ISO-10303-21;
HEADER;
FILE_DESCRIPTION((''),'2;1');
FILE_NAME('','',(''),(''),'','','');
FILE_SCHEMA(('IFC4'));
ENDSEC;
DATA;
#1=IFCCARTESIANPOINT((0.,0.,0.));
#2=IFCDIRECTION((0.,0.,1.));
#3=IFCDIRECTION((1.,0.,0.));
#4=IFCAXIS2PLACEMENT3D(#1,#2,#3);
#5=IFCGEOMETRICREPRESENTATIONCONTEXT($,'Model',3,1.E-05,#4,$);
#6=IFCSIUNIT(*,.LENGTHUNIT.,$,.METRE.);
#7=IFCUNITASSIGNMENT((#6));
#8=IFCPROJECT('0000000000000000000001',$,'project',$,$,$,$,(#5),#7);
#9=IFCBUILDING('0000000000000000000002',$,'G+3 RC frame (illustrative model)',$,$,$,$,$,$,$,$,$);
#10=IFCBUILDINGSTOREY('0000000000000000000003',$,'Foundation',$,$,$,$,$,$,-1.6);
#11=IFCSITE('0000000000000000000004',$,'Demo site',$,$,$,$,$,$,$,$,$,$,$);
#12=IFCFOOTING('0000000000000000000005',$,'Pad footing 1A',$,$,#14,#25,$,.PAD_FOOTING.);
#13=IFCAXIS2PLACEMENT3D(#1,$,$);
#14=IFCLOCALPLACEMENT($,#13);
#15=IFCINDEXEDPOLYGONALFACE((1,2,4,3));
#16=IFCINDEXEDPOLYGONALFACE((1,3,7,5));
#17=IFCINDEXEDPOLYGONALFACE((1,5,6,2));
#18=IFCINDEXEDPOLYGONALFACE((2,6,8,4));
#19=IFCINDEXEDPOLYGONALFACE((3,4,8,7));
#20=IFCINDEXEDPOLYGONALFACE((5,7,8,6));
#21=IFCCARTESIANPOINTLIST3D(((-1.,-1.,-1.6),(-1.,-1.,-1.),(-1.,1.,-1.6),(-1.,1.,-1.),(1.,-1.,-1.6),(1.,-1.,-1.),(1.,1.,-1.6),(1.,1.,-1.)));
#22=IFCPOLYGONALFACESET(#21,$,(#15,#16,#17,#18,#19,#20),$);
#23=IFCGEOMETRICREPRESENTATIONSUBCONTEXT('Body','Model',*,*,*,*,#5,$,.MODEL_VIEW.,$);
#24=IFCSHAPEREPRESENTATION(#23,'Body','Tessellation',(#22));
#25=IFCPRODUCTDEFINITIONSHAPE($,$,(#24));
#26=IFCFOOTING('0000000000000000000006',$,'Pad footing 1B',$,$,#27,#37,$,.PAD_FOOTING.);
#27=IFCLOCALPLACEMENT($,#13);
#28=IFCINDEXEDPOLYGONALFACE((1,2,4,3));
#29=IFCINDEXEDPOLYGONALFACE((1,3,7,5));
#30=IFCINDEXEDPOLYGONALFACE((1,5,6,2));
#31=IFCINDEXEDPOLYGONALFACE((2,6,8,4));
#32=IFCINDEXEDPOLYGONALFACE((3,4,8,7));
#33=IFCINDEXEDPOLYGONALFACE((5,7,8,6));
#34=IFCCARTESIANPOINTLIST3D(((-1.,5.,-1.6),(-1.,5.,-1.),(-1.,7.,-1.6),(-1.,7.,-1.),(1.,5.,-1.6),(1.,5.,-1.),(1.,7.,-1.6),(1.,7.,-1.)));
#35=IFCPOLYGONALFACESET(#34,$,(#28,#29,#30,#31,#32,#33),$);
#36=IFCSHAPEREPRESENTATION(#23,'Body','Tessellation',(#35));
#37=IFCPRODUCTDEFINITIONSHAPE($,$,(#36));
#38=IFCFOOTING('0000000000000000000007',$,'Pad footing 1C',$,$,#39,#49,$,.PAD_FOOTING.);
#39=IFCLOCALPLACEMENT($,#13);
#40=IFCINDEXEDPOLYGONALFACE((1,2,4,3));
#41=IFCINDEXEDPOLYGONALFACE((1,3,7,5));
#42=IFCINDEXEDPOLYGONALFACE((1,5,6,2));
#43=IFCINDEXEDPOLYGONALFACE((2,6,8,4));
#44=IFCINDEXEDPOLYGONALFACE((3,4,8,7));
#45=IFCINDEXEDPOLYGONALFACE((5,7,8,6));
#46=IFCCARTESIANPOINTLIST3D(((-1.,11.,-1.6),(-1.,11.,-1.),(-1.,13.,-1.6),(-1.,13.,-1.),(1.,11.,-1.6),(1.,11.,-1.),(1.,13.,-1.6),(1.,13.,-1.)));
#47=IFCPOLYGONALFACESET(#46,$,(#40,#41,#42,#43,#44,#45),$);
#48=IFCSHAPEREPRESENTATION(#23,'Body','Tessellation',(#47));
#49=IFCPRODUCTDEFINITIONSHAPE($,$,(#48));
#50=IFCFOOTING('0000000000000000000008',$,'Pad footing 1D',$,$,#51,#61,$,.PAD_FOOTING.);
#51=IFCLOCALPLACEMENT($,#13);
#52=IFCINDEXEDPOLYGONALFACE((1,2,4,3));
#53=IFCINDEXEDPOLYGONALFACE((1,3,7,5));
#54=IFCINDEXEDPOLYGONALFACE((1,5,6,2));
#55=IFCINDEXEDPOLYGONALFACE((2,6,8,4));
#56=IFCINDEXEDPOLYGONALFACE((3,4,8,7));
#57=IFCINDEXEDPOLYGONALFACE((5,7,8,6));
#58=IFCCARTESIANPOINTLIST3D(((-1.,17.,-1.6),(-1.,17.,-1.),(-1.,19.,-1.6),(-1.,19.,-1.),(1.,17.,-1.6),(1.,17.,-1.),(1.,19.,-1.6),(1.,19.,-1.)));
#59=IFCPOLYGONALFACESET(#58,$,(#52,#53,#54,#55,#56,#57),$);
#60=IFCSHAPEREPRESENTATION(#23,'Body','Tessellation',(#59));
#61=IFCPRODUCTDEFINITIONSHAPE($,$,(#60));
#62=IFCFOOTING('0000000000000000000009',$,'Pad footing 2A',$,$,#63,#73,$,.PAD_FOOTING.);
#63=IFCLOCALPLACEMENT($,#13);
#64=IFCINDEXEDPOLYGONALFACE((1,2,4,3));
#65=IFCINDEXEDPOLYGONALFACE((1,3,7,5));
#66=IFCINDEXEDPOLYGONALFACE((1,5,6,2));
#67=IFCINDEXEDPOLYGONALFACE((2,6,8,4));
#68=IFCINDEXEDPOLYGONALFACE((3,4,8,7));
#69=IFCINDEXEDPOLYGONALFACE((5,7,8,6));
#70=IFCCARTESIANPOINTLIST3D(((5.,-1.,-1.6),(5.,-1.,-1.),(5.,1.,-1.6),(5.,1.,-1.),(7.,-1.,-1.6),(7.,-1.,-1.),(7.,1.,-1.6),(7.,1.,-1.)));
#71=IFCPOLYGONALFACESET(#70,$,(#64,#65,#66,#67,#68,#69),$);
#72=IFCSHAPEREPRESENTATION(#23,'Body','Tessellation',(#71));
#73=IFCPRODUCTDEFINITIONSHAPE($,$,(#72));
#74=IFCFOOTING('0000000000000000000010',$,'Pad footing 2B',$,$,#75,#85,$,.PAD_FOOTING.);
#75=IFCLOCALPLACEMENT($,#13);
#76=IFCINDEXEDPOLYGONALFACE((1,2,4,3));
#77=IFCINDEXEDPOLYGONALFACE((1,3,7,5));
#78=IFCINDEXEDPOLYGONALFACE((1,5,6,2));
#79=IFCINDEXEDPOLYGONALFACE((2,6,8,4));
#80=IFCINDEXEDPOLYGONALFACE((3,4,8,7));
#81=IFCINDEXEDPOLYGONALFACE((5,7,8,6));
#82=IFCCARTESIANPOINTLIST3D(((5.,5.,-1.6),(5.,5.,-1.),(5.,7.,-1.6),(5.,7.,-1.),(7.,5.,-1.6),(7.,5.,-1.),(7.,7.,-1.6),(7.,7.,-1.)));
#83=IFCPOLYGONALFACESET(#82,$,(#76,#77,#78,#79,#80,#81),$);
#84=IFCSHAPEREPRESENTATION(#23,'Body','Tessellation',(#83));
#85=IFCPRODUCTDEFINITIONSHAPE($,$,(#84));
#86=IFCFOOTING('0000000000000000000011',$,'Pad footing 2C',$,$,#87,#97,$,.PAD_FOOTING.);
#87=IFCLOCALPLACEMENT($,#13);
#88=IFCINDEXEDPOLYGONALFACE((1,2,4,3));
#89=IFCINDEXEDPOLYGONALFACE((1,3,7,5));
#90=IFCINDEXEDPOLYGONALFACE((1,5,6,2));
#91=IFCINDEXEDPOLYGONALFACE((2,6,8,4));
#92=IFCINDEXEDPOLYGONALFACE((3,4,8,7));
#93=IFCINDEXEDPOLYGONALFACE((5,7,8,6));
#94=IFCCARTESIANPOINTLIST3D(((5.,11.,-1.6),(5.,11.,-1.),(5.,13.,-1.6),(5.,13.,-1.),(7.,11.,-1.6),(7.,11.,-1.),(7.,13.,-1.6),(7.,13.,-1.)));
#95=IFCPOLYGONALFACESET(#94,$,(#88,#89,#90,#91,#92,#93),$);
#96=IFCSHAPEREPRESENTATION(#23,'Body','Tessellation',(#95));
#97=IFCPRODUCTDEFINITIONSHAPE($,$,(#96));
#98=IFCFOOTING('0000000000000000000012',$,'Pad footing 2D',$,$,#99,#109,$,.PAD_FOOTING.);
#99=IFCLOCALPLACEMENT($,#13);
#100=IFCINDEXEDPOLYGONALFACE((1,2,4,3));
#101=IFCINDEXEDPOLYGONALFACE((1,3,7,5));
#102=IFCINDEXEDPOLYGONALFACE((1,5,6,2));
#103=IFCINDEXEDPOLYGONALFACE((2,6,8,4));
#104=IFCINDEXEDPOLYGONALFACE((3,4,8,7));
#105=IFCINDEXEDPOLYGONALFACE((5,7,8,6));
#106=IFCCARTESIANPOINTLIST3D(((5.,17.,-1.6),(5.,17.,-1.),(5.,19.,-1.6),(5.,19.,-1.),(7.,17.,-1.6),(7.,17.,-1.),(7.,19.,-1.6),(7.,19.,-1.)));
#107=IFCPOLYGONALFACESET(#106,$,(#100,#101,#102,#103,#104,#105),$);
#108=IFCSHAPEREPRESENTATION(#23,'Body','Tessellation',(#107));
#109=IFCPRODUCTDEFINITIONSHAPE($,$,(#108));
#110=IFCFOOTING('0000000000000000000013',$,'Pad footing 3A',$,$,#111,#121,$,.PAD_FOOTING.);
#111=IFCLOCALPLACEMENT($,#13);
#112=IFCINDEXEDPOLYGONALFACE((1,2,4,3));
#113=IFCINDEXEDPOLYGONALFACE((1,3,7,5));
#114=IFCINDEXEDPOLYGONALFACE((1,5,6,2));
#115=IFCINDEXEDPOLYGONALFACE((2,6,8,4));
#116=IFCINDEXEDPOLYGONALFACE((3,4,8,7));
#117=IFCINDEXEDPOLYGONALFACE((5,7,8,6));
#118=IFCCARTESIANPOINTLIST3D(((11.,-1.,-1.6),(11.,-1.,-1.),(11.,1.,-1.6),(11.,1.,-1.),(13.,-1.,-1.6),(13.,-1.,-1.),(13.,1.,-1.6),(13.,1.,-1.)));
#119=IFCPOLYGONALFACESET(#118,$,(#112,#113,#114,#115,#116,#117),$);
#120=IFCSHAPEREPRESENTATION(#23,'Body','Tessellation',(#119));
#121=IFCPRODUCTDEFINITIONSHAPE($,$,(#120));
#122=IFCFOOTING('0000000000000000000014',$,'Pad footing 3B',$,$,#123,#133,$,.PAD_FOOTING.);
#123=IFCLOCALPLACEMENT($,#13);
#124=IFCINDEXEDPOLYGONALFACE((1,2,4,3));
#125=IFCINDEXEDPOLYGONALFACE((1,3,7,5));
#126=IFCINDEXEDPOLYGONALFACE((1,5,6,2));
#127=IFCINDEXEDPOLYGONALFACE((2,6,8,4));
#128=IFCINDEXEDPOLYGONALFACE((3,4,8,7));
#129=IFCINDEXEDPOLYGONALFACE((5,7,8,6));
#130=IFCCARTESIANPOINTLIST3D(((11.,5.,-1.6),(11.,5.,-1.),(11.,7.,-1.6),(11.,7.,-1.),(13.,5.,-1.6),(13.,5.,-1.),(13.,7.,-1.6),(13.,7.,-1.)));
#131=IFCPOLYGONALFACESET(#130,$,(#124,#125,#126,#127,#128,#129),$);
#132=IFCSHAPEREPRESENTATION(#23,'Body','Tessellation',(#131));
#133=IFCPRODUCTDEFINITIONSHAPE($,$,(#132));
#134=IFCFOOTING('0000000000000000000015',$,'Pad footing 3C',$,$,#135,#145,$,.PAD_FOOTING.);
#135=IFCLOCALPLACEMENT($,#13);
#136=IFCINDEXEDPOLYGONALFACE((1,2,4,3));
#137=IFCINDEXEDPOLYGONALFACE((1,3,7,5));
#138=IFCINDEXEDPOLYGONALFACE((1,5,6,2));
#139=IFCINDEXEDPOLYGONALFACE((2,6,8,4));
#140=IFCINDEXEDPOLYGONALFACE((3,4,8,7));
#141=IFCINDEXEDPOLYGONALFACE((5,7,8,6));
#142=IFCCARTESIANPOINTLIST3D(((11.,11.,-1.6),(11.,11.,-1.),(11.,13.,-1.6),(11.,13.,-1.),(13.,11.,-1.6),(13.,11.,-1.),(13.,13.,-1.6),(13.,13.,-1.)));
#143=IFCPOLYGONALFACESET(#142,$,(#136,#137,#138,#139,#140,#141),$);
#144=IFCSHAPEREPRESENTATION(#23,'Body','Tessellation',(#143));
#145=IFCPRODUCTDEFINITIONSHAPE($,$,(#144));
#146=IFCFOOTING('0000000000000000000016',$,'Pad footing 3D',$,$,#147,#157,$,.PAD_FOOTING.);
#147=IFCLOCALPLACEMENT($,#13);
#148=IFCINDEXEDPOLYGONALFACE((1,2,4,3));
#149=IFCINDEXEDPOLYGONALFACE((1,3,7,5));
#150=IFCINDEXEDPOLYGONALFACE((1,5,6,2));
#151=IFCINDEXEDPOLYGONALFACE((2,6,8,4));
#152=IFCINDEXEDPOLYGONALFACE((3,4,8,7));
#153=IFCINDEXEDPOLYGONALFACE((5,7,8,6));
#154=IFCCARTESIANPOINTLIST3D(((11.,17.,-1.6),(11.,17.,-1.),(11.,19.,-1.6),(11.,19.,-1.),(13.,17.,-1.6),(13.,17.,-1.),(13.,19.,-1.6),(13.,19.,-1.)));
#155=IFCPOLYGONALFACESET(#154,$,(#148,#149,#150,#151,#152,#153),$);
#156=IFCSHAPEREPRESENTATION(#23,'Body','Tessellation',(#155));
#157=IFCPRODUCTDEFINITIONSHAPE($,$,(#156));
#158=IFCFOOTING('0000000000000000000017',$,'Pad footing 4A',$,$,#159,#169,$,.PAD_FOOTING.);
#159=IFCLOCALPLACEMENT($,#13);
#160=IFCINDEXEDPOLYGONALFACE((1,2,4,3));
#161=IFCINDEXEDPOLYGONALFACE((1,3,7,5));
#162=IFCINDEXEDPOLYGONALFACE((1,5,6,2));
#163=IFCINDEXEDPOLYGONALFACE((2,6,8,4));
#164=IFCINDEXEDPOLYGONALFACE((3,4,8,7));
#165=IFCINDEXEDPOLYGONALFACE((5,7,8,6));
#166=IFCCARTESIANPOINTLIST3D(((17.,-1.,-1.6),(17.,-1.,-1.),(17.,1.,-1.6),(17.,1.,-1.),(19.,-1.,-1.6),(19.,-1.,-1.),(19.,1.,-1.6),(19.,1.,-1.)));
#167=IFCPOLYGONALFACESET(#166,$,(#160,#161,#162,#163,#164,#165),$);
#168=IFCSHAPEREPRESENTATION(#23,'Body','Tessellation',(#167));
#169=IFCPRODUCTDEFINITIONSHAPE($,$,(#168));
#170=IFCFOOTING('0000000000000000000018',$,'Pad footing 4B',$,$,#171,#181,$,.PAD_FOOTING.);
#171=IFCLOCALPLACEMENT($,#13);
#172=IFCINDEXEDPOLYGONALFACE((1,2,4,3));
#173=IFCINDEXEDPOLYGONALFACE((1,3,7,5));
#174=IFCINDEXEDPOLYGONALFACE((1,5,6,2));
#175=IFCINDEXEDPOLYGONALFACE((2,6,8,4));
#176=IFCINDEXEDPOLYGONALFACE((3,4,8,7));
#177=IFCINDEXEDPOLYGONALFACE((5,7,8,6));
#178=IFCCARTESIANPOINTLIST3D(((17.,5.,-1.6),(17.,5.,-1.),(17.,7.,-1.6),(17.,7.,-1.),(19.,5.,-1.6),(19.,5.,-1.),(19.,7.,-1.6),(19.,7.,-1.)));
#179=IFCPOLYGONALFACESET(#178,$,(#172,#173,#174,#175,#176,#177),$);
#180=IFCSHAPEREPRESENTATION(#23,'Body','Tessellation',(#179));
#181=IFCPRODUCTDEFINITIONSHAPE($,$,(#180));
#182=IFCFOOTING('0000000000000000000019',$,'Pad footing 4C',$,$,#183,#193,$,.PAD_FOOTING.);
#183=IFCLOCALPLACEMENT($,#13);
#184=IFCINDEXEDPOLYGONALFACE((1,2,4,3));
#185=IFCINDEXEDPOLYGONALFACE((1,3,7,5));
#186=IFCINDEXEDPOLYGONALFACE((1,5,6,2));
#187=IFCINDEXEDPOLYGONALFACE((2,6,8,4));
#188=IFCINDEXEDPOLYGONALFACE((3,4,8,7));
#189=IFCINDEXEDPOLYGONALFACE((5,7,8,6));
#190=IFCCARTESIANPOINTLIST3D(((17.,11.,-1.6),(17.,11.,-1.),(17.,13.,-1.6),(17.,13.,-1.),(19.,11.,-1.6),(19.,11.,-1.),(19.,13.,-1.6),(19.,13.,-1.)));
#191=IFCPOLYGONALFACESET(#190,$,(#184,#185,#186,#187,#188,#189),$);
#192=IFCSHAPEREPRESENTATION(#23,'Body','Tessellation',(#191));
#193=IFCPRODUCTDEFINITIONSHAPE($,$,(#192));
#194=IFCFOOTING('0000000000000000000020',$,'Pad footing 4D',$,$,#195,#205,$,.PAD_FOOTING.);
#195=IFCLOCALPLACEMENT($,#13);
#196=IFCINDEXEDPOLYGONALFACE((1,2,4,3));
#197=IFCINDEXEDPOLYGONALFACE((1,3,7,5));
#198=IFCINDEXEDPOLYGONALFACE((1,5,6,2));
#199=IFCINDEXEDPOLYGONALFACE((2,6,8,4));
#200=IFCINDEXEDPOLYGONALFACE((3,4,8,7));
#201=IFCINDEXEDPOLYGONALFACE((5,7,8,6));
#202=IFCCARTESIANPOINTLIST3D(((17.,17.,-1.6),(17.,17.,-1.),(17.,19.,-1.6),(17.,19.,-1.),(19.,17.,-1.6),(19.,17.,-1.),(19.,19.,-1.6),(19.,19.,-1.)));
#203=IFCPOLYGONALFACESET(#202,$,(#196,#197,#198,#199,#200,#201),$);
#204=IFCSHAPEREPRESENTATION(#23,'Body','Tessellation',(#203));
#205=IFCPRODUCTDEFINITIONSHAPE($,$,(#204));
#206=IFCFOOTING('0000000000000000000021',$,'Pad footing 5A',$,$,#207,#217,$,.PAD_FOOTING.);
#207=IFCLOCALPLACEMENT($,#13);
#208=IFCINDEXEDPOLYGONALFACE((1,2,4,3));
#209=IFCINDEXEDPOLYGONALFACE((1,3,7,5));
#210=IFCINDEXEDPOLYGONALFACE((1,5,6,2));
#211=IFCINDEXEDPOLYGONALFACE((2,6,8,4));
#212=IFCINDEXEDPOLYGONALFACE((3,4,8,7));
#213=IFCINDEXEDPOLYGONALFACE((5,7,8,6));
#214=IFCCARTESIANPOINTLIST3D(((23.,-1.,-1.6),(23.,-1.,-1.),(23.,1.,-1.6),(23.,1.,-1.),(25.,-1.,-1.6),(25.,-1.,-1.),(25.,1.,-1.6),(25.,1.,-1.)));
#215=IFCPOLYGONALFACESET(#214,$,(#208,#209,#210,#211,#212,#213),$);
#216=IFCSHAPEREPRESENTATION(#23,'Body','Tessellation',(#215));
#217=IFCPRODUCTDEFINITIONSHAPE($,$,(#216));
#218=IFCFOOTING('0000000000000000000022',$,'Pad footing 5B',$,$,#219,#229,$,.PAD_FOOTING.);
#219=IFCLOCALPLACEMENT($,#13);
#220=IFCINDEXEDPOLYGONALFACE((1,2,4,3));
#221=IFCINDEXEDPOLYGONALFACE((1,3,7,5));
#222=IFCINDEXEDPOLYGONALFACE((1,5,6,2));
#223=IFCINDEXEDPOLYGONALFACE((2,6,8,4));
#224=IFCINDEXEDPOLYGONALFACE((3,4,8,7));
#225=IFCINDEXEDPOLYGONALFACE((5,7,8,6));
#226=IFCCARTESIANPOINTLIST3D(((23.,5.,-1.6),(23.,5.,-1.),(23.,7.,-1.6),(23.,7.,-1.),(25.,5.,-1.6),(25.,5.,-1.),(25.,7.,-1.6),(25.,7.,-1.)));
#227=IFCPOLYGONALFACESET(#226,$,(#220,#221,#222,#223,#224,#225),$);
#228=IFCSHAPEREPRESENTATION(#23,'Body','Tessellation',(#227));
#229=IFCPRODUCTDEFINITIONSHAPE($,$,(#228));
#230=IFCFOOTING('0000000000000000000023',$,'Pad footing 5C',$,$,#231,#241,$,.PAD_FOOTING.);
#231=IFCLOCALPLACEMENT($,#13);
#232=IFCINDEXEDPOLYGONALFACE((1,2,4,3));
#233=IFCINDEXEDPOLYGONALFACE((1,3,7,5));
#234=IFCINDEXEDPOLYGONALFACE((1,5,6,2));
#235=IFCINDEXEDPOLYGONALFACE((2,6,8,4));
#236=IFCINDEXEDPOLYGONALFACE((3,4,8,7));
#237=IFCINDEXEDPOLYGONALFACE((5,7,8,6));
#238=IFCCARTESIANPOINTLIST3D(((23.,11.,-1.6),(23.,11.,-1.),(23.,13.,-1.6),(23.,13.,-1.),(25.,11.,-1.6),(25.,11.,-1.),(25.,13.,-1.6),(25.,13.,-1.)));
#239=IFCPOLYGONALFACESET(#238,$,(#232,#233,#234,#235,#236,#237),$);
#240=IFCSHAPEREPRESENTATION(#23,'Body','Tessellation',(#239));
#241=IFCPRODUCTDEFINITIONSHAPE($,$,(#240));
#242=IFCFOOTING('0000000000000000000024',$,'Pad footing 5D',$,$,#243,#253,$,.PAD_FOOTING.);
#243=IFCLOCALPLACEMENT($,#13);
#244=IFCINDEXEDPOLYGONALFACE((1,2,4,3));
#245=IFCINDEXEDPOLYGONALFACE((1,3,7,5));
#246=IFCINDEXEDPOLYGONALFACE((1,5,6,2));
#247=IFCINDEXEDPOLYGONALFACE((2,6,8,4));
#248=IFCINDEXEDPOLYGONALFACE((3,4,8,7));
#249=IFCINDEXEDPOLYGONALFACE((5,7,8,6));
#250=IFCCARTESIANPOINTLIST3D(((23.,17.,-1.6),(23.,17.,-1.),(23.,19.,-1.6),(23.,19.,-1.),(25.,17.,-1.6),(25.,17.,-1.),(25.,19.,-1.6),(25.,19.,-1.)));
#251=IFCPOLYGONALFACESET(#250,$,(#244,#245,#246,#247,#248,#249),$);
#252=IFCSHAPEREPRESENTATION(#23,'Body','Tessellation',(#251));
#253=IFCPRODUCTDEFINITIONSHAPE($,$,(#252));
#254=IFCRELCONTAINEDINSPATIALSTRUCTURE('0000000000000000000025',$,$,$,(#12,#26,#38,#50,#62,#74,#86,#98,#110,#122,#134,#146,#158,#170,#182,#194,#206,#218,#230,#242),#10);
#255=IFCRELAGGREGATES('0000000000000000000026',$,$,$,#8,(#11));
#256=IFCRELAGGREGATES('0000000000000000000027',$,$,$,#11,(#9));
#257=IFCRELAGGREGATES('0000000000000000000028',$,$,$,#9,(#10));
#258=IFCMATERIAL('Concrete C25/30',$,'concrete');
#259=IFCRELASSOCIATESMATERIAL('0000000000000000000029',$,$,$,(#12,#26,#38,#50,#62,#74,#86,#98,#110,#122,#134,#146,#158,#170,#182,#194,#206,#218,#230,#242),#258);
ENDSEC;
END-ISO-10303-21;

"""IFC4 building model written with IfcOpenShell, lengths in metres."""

from ifc_helpers import new_model, si_unit, frame, frame_2d, origin, origin_with_axes, place, context, subcontext, project, spatial, rectangle, extrude, material, element, save


model = new_model("IFC4")

# Units and contexts
model_context = context("Model", 3, precision=1e-05, world=origin_with_axes())
body_context = subcontext(model_context, "Body", "Model", "MODEL_VIEW")
ifc_project = project(units=[si_unit("LENGTHUNIT", "METRE")], contexts=[model_context])

# Site, building, storey
site = spatial("IfcSite", under=ifc_project, Name="Demo site")
building = spatial("IfcBuilding", under=site, Name="G+3 RC frame (illustrative model)")
storey = spatial("IfcBuildingStorey", under=building, Name="Foundation", Elevation=-1.6)

# Footings
ifc_material = material(Name="Concrete C25/30", Category="concrete")
for number, where, z_axis, x_axis, name in (
    (1, (-1.0, -1.0, -1.6), (0.0, 0.0, 1.0), (1.0, 0.0, 0.0), "Pad footing 1A"),
    (2, (-1.0, 5.0, -1.6), (0.0, 0.0, 1.0), (1.0, 0.0, 0.0), "Pad footing 1B"),
    (3, (-1.0, 11.0, -1.6), (0.0, 0.0, 1.0), (1.0, 0.0, 0.0), "Pad footing 1C"),
    (4, (-1.0, 17.0, -1.6), (0.0, 0.0, 1.0), (1.0, 0.0, 0.0), "Pad footing 1D"),
    (5, (5.0, -1.0, -1.6), (0.0, 0.0, 1.0), (1.0, 0.0, 0.0), "Pad footing 2A"),
    (6, (5.0, 5.0, -1.6), (0.0, 0.0, 1.0), (1.0, 0.0, 0.0), "Pad footing 2B"),
    (7, (5.0, 11.0, -1.6), (0.0, 0.0, 1.0), (1.0, 0.0, 0.0), "Pad footing 2C"),
    (8, (5.0, 17.0, -1.6), (0.0, 0.0, 1.0), (1.0, 0.0, 0.0), "Pad footing 2D"),
    (9, (11.0, -1.0, -1.6), (0.0, 0.0, 1.0), (1.0, 0.0, 0.0), "Pad footing 3A"),
    (10, (11.0, 5.0, -1.6), (0.0, 0.0, 1.0), (1.0, 0.0, 0.0), "Pad footing 3B"),
    (11, (11.0, 11.0, -1.6), (0.0, 0.0, 1.0), (1.0, 0.0, 0.0), "Pad footing 3C"),
    (12, (11.0, 17.0, -1.6), (0.0, 0.0, 1.0), (1.0, 0.0, 0.0), "Pad footing 3D"),
    (13, (17.0, -1.0, -1.6), (0.0, 0.0, 1.0), (1.0, 0.0, 0.0), "Pad footing 4A"),
    (14, (17.0, 5.0, -1.6), (0.0, 0.0, 1.0), (1.0, 0.0, 0.0), "Pad footing 4B"),
    (15, (17.0, 11.0, -1.6), (0.0, 0.0, 1.0), (1.0, 0.0, 0.0), "Pad footing 4C"),
    (16, (17.0, 17.0, -1.6), (0.0, 0.0, 1.0), (1.0, 0.0, 0.0), "Pad footing 4D"),
    (17, (23.0, -1.0, -1.6), (0.0, 0.0, 1.0), (1.0, 0.0, 0.0), "Pad footing 5A"),
    (18, (23.0, 5.0, -1.6), (0.0, 0.0, 1.0), (1.0, 0.0, 0.0), "Pad footing 5B"),
    (19, (23.0, 11.0, -1.6), (0.0, 0.0, 1.0), (1.0, 0.0, 0.0), "Pad footing 5C"),
    (20, (23.0, 17.0, -1.6), (0.0, 0.0, 1.0), (1.0, 0.0, 0.0), "Pad footing 5D"),
):
    element("IfcFooting", number, at=place(None, frame(where, z_axis=z_axis, x_axis=x_axis)), inside=storey, material=ifc_material, Name=name, PredefinedType="PAD_FOOTING", context=body_context, shape_type="SweptSolid", body=[
        extrude(rectangle(XDim=2.0, YDim=2.0, at=frame_2d((1.0, 1.0))), origin(), (0.0, 0.0, 1.0), 0.6),
    ])

save(model, "model.ifc")
